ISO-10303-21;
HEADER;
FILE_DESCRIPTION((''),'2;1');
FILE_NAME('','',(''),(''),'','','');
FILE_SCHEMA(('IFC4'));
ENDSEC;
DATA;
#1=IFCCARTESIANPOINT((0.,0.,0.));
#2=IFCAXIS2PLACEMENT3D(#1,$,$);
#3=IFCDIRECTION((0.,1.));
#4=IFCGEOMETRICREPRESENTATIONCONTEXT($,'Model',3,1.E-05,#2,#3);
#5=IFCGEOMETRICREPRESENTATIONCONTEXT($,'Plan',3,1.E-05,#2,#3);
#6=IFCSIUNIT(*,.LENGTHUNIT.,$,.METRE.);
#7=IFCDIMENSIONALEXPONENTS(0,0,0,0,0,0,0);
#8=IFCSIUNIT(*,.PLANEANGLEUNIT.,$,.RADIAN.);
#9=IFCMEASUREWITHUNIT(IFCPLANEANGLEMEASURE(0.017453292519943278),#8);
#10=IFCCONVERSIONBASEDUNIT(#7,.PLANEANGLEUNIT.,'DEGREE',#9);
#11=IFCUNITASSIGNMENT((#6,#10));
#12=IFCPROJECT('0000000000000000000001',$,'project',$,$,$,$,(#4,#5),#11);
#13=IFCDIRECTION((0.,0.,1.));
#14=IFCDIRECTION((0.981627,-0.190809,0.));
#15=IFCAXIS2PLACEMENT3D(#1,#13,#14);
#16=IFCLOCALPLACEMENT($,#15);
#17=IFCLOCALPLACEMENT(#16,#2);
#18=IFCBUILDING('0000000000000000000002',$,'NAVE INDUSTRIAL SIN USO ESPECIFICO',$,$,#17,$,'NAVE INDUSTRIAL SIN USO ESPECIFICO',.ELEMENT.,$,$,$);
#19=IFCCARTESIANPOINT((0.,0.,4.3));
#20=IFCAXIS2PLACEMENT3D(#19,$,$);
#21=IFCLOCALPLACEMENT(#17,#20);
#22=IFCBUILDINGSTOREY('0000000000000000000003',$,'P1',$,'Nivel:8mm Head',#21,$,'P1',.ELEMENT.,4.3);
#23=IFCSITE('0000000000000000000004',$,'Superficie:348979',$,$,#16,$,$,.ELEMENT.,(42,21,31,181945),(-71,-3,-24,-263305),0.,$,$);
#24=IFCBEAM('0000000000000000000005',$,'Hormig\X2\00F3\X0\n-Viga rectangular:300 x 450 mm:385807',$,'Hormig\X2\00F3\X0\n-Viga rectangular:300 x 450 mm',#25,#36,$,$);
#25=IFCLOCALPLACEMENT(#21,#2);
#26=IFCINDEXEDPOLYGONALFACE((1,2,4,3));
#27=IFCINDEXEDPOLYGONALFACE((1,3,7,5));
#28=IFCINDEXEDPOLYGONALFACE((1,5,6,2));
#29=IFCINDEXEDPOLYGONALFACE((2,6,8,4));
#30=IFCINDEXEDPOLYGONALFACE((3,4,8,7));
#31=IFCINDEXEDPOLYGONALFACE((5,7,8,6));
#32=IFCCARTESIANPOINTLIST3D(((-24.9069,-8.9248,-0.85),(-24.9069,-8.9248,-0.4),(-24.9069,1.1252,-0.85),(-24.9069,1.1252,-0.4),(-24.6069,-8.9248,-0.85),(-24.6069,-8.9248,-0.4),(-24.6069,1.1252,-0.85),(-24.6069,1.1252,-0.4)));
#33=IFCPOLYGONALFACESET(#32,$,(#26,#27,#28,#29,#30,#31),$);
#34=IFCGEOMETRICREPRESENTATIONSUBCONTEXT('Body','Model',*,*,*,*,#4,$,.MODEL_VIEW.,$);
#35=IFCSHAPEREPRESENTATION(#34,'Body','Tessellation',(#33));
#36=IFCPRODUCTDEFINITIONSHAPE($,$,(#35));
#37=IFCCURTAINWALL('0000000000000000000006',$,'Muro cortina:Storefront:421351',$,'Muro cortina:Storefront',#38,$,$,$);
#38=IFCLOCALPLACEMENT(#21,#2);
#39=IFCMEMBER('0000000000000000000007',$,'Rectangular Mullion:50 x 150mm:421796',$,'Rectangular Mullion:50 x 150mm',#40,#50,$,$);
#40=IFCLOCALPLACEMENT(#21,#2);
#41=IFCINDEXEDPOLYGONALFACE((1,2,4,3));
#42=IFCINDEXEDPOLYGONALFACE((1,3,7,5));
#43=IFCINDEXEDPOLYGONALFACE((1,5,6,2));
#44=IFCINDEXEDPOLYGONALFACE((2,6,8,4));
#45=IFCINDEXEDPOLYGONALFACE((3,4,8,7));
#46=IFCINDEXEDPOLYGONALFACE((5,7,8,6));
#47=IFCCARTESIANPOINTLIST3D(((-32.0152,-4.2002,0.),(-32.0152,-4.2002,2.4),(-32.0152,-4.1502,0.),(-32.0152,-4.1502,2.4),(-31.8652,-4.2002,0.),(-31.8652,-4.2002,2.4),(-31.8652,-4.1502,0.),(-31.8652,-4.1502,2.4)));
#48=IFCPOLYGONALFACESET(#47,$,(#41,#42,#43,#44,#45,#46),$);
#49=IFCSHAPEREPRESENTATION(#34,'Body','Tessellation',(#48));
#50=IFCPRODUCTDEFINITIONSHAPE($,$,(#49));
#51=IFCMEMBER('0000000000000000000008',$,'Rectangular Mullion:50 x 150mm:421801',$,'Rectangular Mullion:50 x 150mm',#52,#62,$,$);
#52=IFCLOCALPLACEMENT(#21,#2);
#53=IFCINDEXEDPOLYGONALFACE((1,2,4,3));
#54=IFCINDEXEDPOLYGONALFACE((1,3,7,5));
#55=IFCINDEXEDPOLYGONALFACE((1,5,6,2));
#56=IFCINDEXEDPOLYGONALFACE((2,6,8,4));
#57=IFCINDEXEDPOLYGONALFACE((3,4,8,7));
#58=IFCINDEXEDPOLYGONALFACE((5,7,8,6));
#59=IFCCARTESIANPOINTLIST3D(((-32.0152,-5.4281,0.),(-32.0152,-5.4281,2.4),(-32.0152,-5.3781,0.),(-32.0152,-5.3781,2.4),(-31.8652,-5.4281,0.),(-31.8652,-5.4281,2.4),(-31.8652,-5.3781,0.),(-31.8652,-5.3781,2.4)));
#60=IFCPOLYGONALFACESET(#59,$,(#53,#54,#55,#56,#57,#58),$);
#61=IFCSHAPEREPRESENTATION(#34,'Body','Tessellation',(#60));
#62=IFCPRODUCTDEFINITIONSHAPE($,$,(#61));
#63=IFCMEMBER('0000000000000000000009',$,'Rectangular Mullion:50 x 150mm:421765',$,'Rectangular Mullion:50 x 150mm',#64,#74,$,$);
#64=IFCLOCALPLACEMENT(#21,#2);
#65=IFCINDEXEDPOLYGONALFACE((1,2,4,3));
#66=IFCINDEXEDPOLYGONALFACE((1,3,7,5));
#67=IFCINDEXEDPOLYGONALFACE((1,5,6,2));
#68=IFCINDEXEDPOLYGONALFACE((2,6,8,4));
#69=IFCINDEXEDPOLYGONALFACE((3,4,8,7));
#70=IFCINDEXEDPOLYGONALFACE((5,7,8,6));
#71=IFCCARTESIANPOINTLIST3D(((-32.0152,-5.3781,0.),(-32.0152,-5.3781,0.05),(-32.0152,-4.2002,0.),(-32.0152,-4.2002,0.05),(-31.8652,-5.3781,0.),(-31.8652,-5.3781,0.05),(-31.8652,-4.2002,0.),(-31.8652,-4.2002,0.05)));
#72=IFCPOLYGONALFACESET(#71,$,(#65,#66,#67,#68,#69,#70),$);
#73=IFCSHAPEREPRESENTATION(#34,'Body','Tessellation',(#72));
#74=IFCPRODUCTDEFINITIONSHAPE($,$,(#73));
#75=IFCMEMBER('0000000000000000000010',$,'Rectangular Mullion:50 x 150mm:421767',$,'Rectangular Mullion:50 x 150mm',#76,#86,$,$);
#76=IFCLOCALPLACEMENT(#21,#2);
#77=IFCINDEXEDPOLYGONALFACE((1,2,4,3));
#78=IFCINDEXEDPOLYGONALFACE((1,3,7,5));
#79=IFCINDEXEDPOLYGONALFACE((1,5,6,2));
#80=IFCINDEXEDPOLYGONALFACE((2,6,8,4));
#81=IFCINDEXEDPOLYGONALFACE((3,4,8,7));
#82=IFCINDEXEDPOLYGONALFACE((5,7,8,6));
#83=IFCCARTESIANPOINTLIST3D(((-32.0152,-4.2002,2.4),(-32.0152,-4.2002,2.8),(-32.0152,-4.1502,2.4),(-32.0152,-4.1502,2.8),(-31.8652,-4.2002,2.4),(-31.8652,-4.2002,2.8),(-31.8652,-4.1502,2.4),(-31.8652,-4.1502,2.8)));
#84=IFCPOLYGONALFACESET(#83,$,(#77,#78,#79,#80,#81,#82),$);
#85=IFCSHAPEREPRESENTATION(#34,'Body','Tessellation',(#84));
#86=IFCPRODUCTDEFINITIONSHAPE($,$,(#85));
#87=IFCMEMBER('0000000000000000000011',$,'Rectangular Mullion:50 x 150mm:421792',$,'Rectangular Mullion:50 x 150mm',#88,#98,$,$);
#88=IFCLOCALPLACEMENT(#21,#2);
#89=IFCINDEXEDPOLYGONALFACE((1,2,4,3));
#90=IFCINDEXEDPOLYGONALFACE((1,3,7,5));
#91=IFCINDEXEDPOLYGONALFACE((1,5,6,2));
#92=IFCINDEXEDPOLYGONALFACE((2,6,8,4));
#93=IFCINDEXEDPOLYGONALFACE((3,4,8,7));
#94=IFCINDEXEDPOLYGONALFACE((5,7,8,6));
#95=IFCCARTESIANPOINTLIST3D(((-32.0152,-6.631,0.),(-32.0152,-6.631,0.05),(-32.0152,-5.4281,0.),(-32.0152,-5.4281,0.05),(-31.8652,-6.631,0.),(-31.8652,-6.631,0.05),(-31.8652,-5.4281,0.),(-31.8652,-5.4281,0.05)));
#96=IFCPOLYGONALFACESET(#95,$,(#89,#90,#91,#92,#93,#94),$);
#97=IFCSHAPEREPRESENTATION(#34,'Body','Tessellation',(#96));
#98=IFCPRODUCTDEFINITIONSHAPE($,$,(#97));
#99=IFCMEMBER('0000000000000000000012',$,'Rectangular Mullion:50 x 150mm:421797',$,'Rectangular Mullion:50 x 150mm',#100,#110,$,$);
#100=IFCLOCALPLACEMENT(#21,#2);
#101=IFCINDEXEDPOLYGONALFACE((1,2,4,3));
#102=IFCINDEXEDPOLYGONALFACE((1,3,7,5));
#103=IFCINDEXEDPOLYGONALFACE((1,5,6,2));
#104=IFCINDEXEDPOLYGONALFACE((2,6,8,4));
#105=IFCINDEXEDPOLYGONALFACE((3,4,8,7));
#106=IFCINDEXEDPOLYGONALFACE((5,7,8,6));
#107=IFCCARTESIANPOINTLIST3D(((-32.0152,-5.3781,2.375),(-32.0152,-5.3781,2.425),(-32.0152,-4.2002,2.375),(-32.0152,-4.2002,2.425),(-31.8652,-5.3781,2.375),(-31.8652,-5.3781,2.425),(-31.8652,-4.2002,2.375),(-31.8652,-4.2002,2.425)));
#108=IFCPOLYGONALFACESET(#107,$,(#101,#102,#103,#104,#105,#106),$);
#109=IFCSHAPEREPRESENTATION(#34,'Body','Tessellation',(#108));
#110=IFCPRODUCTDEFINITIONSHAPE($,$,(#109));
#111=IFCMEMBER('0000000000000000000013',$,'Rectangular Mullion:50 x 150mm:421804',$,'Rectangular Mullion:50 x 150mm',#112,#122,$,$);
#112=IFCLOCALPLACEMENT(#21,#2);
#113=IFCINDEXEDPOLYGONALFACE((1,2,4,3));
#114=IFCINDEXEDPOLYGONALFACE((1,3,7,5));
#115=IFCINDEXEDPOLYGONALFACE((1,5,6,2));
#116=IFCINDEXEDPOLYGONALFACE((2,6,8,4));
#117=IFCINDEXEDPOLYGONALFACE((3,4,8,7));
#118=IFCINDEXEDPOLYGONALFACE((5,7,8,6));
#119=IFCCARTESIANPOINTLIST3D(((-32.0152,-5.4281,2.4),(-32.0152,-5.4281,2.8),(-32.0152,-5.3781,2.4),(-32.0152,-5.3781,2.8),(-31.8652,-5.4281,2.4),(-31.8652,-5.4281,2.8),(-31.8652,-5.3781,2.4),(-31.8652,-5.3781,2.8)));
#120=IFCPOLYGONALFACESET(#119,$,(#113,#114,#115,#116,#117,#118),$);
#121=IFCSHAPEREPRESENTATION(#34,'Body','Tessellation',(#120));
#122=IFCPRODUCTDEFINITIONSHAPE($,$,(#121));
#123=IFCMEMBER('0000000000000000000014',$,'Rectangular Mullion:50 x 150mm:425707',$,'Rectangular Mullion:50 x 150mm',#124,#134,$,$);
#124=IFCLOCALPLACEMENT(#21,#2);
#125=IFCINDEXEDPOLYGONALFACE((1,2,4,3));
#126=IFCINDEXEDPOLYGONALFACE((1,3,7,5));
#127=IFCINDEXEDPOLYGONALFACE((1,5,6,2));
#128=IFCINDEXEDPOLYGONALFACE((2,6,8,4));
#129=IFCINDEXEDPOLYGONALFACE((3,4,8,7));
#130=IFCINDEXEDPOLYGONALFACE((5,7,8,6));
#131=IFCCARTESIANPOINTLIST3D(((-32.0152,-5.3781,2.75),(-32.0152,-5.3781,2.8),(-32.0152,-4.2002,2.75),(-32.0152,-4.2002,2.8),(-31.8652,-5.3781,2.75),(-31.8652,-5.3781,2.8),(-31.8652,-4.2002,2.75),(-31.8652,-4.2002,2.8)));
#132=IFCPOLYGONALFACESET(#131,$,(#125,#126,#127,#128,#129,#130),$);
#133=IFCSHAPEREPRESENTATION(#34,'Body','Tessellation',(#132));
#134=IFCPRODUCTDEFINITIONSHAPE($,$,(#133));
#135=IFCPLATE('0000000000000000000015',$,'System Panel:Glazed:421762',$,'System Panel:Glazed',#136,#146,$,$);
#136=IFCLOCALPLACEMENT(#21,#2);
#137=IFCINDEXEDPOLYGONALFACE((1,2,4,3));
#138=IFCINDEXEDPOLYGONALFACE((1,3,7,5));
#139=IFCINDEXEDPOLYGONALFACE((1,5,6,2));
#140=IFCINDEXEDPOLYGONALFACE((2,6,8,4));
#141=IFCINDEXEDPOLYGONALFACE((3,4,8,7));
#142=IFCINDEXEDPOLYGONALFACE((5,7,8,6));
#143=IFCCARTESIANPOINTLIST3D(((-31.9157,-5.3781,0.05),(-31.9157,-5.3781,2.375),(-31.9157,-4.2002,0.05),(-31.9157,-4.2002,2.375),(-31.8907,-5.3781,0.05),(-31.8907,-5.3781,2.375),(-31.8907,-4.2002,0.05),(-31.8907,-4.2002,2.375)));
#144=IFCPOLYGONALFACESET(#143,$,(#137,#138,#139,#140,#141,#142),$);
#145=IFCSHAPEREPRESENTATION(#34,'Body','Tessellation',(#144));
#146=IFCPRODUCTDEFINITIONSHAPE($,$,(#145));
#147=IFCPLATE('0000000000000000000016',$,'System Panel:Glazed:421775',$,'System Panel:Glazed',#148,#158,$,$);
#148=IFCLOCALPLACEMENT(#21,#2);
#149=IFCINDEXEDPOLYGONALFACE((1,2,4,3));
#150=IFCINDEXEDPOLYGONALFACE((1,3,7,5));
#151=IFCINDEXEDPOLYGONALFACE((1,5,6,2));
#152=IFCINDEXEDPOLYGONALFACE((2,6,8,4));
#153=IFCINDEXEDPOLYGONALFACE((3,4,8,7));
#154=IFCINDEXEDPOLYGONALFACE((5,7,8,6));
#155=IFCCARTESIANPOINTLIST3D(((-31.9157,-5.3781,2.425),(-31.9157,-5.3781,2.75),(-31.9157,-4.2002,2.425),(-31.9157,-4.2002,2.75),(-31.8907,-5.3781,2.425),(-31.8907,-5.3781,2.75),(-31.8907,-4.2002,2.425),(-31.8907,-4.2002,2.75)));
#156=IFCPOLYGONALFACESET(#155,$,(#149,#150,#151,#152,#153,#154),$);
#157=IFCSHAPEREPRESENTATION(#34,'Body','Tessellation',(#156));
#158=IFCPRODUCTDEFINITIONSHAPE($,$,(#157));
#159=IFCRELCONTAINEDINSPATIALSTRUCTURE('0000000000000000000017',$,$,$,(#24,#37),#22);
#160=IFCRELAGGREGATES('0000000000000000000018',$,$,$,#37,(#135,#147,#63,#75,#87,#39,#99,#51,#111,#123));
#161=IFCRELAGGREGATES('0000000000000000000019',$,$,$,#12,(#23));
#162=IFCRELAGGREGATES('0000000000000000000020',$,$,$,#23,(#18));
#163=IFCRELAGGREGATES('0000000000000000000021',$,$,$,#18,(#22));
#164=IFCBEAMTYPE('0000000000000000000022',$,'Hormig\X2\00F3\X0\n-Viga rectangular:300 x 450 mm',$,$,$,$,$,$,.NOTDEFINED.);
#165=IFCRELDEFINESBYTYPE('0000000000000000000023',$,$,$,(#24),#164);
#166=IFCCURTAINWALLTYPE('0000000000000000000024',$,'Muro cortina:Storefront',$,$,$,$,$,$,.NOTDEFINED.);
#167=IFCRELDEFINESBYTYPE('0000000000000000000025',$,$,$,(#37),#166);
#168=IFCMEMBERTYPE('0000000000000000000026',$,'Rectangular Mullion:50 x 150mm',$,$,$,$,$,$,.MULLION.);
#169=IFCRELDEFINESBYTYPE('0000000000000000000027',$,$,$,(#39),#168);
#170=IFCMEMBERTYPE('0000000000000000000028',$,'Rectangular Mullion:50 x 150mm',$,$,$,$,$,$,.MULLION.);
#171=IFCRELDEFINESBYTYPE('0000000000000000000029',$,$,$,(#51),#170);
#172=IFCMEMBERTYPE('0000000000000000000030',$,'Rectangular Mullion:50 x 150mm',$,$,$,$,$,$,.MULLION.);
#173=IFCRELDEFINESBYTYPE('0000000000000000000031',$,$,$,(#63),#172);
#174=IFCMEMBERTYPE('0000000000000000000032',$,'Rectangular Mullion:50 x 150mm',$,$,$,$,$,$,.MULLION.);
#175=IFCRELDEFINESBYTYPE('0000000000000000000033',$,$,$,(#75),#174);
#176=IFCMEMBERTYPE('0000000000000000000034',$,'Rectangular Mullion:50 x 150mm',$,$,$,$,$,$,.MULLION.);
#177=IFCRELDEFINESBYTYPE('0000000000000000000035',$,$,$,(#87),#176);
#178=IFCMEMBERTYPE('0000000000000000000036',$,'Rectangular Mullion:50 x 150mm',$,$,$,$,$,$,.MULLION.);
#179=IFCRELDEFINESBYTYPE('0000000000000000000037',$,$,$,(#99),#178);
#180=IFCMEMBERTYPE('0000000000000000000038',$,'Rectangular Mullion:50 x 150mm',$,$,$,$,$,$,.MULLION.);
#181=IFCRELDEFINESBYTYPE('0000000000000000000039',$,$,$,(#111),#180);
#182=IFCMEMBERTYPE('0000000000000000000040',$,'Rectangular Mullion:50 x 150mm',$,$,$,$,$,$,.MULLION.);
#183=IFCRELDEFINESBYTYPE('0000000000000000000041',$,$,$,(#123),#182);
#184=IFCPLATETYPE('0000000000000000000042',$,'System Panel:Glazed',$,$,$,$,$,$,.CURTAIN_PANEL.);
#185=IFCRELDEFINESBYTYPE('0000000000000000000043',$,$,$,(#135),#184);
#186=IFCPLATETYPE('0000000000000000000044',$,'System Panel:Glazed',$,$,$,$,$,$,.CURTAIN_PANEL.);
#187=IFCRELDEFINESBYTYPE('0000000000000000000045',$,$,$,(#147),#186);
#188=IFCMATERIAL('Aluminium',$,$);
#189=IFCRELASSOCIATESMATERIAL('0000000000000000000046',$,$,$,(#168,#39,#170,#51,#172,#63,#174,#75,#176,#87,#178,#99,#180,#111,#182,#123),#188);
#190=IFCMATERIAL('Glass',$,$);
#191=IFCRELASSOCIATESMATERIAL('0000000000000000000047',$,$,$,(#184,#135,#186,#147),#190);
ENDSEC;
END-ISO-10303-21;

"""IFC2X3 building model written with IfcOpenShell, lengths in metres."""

from ifc_helpers import new_model, entity, si_unit, converted_unit, direction, frame, frame_2d, origin, origin_2d_with_axis, place, context, subcontext, project, spatial, rectangle, extrude, source, transform, mapped, material, type_object, type_shapes, element, aggregate, save


model = new_model("IFC2X3")

# Units and contexts
model_context = context("Model", 3, precision=1e-05, world=origin(), true_north=direction((0.0, 1.0)))
plan_context = context("Plan", 3, precision=1e-05, world=origin(), true_north=direction((0.0, 1.0)))
body_context = subcontext(model_context, "Body", "Model", "MODEL_VIEW")
ifc_project = project(units=[si_unit("LENGTHUNIT", "METRE"), converted_unit("PLANEANGLEUNIT", "DEGREE", entity("IfcPlaneAngleMeasure", 0.017453292519943278), si_unit("PLANEANGLEUNIT", "RADIAN"), dimensions=[0, 0, 0, 0, 0, 0, 0])], contexts=[model_context, plan_context])

# Site, building, storey
site_placement = place(None, frame((0.0, 0.0, 0.0), z_axis=(0.0, 0.0, 1.0), x_axis=(0.981627, -0.190809, 0.0)))
site = spatial("IfcSite", under=ifc_project, at=site_placement, Name="Superficie:348979", CompositionType="ELEMENT", RefLatitude=(42, 21, 31, 181945), RefLongitude=(-71, -3, -24, -263305), RefElevation=0.0)
building_placement = place(site_placement, origin())
building = spatial("IfcBuilding", under=site, at=building_placement, Name="NAVE INDUSTRIAL SIN USO ESPECIFICO", LongName="NAVE INDUSTRIAL SIN USO ESPECIFICO", CompositionType="ELEMENT")
storey_placement = place(building_placement, frame((0.0, 0.0, 4.3)))
storey = spatial("IfcBuildingStorey", under=building, at=storey_placement, Name="P1", ObjectType="Nivel:8mm Head", LongName="P1", CompositionType="ELEMENT", Elevation=4.3)

# Beam
beam_type = type_object("IfcBeamType", Name="Hormigón-Viga rectangular:300 x 450 mm", PredefinedType="NOTDEFINED")
beam_placement = place(storey_placement, frame((-24.7569, 1.7252, -0.4), z_axis=(0.0, 0.0, 1.0), x_axis=(0.0, -1.0, 0.0)))
element("IfcBeam", 1, at=beam_placement, inside=storey, type_object=beam_type, Name="Hormigón-Viga rectangular:300 x 450 mm:385807", ObjectType="Hormigón-Viga rectangular:300 x 450 mm", context=body_context, shape_type="SweptSolid", body=[
    extrude(rectangle(XDim=0.45, YDim=0.3, at=frame_2d((0.0, 0.0), x_axis=(1.0, 0.0))), frame((0.6, 0.0, -0.225), z_axis=(1.0, 0.0, 0.0), x_axis=(0.0, 0.0, -1.0)), (0.0, 0.0, 1.0), 10.05),
])

# Curtain wall, members
curtain_wall_type = type_object("IfcCurtainWallType", Name="Muro cortina:Storefront", PredefinedType="NOTDEFINED")
curtain_wall_placement = place(storey_placement, frame((0.0, 0.0, -4.3)))
curtain_wall = element("IfcCurtainWall", 2, at=curtain_wall_placement, inside=storey, type_object=curtain_wall_type, Name="Muro cortina:Storefront:421351", ObjectType="Muro cortina:Storefront")
ifc_material_1 = material(Name="Aluminium")
member_type_1 = type_object("IfcMemberType", Name="Rectangular Mullion:50 x 150mm", PredefinedType="MULLION", material=ifc_material_1)
shared_shape_1 = source(origin(), body_context, "Body", "SweptSolid", [
    extrude(rectangle(XDim=0.05, YDim=0.15, at=origin_2d_with_axis()), frame((-0.025, 0.0, -2.4), z_axis=(0.0, 0.0, 1.0), x_axis=(-1.0, 0.0, 0.0)), (0.0, 0.0, 1.0), 2.4),
])
type_shapes(member_type_1, [shared_shape_1])
member_1_placement = place(curtain_wall_placement, frame((-31.9402, -4.1502, 6.7), z_axis=(0.0, 0.0, 1.0), x_axis=(0.0, 1.0, 0.0)))
member_1 = element("IfcMember", 3, at=member_1_placement, type_object=member_type_1, material=ifc_material_1, Name="Rectangular Mullion:50 x 150mm:421796", ObjectType="Rectangular Mullion:50 x 150mm", context=body_context, shape_type="MappedRepresentation", body=[
    mapped(shared_shape_1, transform((0.0, 0.0, 0.0), scale=1.0)),
])
member_type_2 = type_object("IfcMemberType", Name="Rectangular Mullion:50 x 150mm", PredefinedType="MULLION", material=ifc_material_1)
shared_shape_2 = source(origin(), body_context, "Body", "SweptSolid", [
    extrude(rectangle(XDim=0.05, YDim=0.15, at=origin_2d_with_axis()), frame((0.0, 0.0, -2.4), z_axis=(0.0, 0.0, 1.0), x_axis=(-1.0, 0.0, 0.0)), (0.0, 0.0, 1.0), 2.4),
])
type_shapes(member_type_2, [shared_shape_2])
member_2_placement = place(curtain_wall_placement, frame((-31.9402, -5.4031, 4.3), z_axis=(0.0, 0.0, -1.0), x_axis=(0.0, -1.0, 0.0)))
member_2 = element("IfcMember", 4, at=member_2_placement, type_object=member_type_2, material=ifc_material_1, Name="Rectangular Mullion:50 x 150mm:421801", ObjectType="Rectangular Mullion:50 x 150mm", context=body_context, shape_type="MappedRepresentation", body=[
    mapped(shared_shape_2, transform((0.0, 0.0, 0.0), scale=1.0)),
])
member_type_3 = type_object("IfcMemberType", Name="Rectangular Mullion:50 x 150mm", PredefinedType="MULLION", material=ifc_material_1)
shared_shape_3 = source(origin(), body_context, "Body", "SweptSolid", [
    extrude(rectangle(XDim=0.05, YDim=0.15, at=origin_2d_with_axis()), frame((-0.025, 0.0, -1.1779), z_axis=(0.0, 0.0, 1.0), x_axis=(-1.0, 0.0, 0.0)), (0.0, 0.0, 1.0), 1.1779),
])
type_shapes(member_type_3, [shared_shape_3])
member_3_placement = place(curtain_wall_placement, frame((-31.9402, -4.2002, 4.3), z_axis=(0.0, 1.0, 0.0), x_axis=(0.0, 0.0, -1.0)))
member_3 = element("IfcMember", 5, at=member_3_placement, type_object=member_type_3, material=ifc_material_1, Name="Rectangular Mullion:50 x 150mm:421765", ObjectType="Rectangular Mullion:50 x 150mm", context=body_context, shape_type="MappedRepresentation", body=[
    mapped(shared_shape_3, transform((0.0, 0.0, 0.0), scale=1.0)),
])
member_type_4 = type_object("IfcMemberType", Name="Rectangular Mullion:50 x 150mm", PredefinedType="MULLION", material=ifc_material_1)
shared_shape_4 = source(origin(), body_context, "Body", "SweptSolid", [
    extrude(rectangle(XDim=0.05, YDim=0.15, at=origin_2d_with_axis()), frame((-0.025, 0.0, -0.4), z_axis=(0.0, 0.0, 1.0), x_axis=(-1.0, 0.0, 0.0)), (0.0, 0.0, 1.0), 0.4),
])
type_shapes(member_type_4, [shared_shape_4])
member_4_placement = place(curtain_wall_placement, frame((-31.9402, -4.1502, 7.1), z_axis=(0.0, 0.0, 1.0), x_axis=(0.0, 1.0, 0.0)))
member_4 = element("IfcMember", 6, at=member_4_placement, type_object=member_type_4, material=ifc_material_1, Name="Rectangular Mullion:50 x 150mm:421767", ObjectType="Rectangular Mullion:50 x 150mm", context=body_context, shape_type="MappedRepresentation", body=[
    mapped(shared_shape_4, transform((0.0, 0.0, 0.0), scale=1.0)),
])
member_type_5 = type_object("IfcMemberType", Name="Rectangular Mullion:50 x 150mm", PredefinedType="MULLION", material=ifc_material_1)
shared_shape_5 = source(origin(), body_context, "Body", "SweptSolid", [
    extrude(rectangle(XDim=0.05, YDim=0.15, at=origin_2d_with_axis()), frame((-0.025, 0.0, -1.2029), z_axis=(0.0, 0.0, 1.0), x_axis=(-1.0, 0.0, 0.0)), (0.0, 0.0, 1.0), 1.2029),
])
type_shapes(member_type_5, [shared_shape_5])
member_5_placement = place(curtain_wall_placement, frame((-31.9402, -5.4281, 4.3), z_axis=(0.0, 1.0, 0.0), x_axis=(0.0, 0.0, -1.0)))
member_5 = element("IfcMember", 7, at=member_5_placement, type_object=member_type_5, material=ifc_material_1, Name="Rectangular Mullion:50 x 150mm:421792", ObjectType="Rectangular Mullion:50 x 150mm", context=body_context, shape_type="MappedRepresentation", body=[
    mapped(shared_shape_5, transform((0.0, 0.0, 0.0), scale=1.0)),
])
member_type_6 = type_object("IfcMemberType", Name="Rectangular Mullion:50 x 150mm", PredefinedType="MULLION", material=ifc_material_1)
shared_shape_6 = source(origin(), body_context, "Body", "SweptSolid", [
    extrude(rectangle(XDim=0.05, YDim=0.15, at=origin_2d_with_axis()), frame((0.0, 0.0, -1.1779), z_axis=(0.0, 0.0, 1.0), x_axis=(-1.0, 0.0, 0.0)), (0.0, 0.0, 1.0), 1.1779),
])
type_shapes(member_type_6, [shared_shape_6])
member_6_placement = place(curtain_wall_placement, frame((-31.9402, -5.3781, 6.7), z_axis=(0.0, -1.0, 0.0), x_axis=(0.0, 0.0, 1.0)))
member_6 = element("IfcMember", 8, at=member_6_placement, type_object=member_type_6, material=ifc_material_1, Name="Rectangular Mullion:50 x 150mm:421797", ObjectType="Rectangular Mullion:50 x 150mm", context=body_context, shape_type="MappedRepresentation", body=[
    mapped(shared_shape_6, transform((0.0, 0.0, 0.0), scale=1.0)),
])
member_type_7 = type_object("IfcMemberType", Name="Rectangular Mullion:50 x 150mm", PredefinedType="MULLION", material=ifc_material_1)
shared_shape_7 = source(origin(), body_context, "Body", "SweptSolid", [
    extrude(rectangle(XDim=0.05, YDim=0.15, at=origin_2d_with_axis()), frame((0.0, 0.0, -0.4), z_axis=(0.0, 0.0, 1.0), x_axis=(-1.0, 0.0, 0.0)), (0.0, 0.0, 1.0), 0.4),
])
type_shapes(member_type_7, [shared_shape_7])
member_7_placement = place(curtain_wall_placement, frame((-31.9402, -5.4031, 6.7), z_axis=(0.0, 0.0, -1.0), x_axis=(0.0, -1.0, 0.0)))
member_7 = element("IfcMember", 9, at=member_7_placement, type_object=member_type_7, material=ifc_material_1, Name="Rectangular Mullion:50 x 150mm:421804", ObjectType="Rectangular Mullion:50 x 150mm", context=body_context, shape_type="MappedRepresentation", body=[
    mapped(shared_shape_7, transform((0.0, 0.0, 0.0), scale=1.0)),
])
member_type_8 = type_object("IfcMemberType", Name="Rectangular Mullion:50 x 150mm", PredefinedType="MULLION", material=ifc_material_1)
shared_shape_8 = source(origin(), body_context, "Body", "SweptSolid", [
    extrude(rectangle(XDim=0.05, YDim=0.15, at=origin_2d_with_axis()), frame((-0.025, 0.0, -1.1779), z_axis=(0.0, 0.0, 1.0), x_axis=(-1.0, 0.0, 0.0)), (0.0, 0.0, 1.0), 1.1779),
])
type_shapes(member_type_8, [shared_shape_8])
member_8_placement = place(curtain_wall_placement, frame((-31.9402, -5.3781, 7.1), z_axis=(0.0, -1.0, 0.0), x_axis=(0.0, 0.0, 1.0)))
member_8 = element("IfcMember", 10, at=member_8_placement, type_object=member_type_8, material=ifc_material_1, Name="Rectangular Mullion:50 x 150mm:425707", ObjectType="Rectangular Mullion:50 x 150mm", context=body_context, shape_type="MappedRepresentation", body=[
    mapped(shared_shape_8, transform((0.0, 0.0, 0.0), scale=1.0)),
])

# Plates
ifc_material_2 = material(Name="Glass")
plate_type_1 = type_object("IfcPlateType", Name="System Panel:Glazed", PredefinedType="CURTAIN_PANEL", material=ifc_material_2)
shared_shape_9 = source(origin(), body_context, "Body", "SweptSolid", [
    extrude(rectangle(XDim=0.025, YDim=1.1779, at=origin_2d_with_axis()), frame((0.589, 0.0125, 0.0), z_axis=(0.0, 0.0, 1.0), x_axis=(0.0, 1.0, 0.0)), (0.0, 0.0, 1.0), 2.325),
])
type_shapes(plate_type_1, [shared_shape_9])
plate_1_placement = place(curtain_wall_placement, frame((-31.9157, -4.2002, 4.35), z_axis=(0.0, 0.0, 1.0), x_axis=(0.0, -1.0, 0.0)))
plate_1 = element("IfcPlate", 11, at=plate_1_placement, type_object=plate_type_1, material=ifc_material_2, Name="System Panel:Glazed:421762", ObjectType="System Panel:Glazed", context=body_context, shape_type="MappedRepresentation", body=[
    mapped(shared_shape_9, transform((0.0, 0.0, 0.0), scale=1.0)),
])
plate_type_2 = type_object("IfcPlateType", Name="System Panel:Glazed", PredefinedType="CURTAIN_PANEL", material=ifc_material_2)
shared_shape_10 = source(origin(), body_context, "Body", "SweptSolid", [
    extrude(rectangle(XDim=0.025, YDim=1.1779, at=origin_2d_with_axis()), frame((0.589, 0.0125, 0.0), z_axis=(0.0, 0.0, 1.0), x_axis=(0.0, 1.0, 0.0)), (0.0, 0.0, 1.0), 0.325),
])
type_shapes(plate_type_2, [shared_shape_10])
plate_2_placement = place(curtain_wall_placement, frame((-31.9157, -4.2002, 6.725), z_axis=(0.0, 0.0, 1.0), x_axis=(0.0, -1.0, 0.0)))
plate_2 = element("IfcPlate", 12, at=plate_2_placement, type_object=plate_type_2, material=ifc_material_2, Name="System Panel:Glazed:421775", ObjectType="System Panel:Glazed", context=body_context, shape_type="MappedRepresentation", body=[
    mapped(shared_shape_10, transform((0.0, 0.0, 0.0), scale=1.0)),
])
aggregate(curtain_wall, [plate_1, plate_2, member_3, member_4, member_5, member_1, member_6, member_2, member_7, member_8])

save(model, "model.ifc")
